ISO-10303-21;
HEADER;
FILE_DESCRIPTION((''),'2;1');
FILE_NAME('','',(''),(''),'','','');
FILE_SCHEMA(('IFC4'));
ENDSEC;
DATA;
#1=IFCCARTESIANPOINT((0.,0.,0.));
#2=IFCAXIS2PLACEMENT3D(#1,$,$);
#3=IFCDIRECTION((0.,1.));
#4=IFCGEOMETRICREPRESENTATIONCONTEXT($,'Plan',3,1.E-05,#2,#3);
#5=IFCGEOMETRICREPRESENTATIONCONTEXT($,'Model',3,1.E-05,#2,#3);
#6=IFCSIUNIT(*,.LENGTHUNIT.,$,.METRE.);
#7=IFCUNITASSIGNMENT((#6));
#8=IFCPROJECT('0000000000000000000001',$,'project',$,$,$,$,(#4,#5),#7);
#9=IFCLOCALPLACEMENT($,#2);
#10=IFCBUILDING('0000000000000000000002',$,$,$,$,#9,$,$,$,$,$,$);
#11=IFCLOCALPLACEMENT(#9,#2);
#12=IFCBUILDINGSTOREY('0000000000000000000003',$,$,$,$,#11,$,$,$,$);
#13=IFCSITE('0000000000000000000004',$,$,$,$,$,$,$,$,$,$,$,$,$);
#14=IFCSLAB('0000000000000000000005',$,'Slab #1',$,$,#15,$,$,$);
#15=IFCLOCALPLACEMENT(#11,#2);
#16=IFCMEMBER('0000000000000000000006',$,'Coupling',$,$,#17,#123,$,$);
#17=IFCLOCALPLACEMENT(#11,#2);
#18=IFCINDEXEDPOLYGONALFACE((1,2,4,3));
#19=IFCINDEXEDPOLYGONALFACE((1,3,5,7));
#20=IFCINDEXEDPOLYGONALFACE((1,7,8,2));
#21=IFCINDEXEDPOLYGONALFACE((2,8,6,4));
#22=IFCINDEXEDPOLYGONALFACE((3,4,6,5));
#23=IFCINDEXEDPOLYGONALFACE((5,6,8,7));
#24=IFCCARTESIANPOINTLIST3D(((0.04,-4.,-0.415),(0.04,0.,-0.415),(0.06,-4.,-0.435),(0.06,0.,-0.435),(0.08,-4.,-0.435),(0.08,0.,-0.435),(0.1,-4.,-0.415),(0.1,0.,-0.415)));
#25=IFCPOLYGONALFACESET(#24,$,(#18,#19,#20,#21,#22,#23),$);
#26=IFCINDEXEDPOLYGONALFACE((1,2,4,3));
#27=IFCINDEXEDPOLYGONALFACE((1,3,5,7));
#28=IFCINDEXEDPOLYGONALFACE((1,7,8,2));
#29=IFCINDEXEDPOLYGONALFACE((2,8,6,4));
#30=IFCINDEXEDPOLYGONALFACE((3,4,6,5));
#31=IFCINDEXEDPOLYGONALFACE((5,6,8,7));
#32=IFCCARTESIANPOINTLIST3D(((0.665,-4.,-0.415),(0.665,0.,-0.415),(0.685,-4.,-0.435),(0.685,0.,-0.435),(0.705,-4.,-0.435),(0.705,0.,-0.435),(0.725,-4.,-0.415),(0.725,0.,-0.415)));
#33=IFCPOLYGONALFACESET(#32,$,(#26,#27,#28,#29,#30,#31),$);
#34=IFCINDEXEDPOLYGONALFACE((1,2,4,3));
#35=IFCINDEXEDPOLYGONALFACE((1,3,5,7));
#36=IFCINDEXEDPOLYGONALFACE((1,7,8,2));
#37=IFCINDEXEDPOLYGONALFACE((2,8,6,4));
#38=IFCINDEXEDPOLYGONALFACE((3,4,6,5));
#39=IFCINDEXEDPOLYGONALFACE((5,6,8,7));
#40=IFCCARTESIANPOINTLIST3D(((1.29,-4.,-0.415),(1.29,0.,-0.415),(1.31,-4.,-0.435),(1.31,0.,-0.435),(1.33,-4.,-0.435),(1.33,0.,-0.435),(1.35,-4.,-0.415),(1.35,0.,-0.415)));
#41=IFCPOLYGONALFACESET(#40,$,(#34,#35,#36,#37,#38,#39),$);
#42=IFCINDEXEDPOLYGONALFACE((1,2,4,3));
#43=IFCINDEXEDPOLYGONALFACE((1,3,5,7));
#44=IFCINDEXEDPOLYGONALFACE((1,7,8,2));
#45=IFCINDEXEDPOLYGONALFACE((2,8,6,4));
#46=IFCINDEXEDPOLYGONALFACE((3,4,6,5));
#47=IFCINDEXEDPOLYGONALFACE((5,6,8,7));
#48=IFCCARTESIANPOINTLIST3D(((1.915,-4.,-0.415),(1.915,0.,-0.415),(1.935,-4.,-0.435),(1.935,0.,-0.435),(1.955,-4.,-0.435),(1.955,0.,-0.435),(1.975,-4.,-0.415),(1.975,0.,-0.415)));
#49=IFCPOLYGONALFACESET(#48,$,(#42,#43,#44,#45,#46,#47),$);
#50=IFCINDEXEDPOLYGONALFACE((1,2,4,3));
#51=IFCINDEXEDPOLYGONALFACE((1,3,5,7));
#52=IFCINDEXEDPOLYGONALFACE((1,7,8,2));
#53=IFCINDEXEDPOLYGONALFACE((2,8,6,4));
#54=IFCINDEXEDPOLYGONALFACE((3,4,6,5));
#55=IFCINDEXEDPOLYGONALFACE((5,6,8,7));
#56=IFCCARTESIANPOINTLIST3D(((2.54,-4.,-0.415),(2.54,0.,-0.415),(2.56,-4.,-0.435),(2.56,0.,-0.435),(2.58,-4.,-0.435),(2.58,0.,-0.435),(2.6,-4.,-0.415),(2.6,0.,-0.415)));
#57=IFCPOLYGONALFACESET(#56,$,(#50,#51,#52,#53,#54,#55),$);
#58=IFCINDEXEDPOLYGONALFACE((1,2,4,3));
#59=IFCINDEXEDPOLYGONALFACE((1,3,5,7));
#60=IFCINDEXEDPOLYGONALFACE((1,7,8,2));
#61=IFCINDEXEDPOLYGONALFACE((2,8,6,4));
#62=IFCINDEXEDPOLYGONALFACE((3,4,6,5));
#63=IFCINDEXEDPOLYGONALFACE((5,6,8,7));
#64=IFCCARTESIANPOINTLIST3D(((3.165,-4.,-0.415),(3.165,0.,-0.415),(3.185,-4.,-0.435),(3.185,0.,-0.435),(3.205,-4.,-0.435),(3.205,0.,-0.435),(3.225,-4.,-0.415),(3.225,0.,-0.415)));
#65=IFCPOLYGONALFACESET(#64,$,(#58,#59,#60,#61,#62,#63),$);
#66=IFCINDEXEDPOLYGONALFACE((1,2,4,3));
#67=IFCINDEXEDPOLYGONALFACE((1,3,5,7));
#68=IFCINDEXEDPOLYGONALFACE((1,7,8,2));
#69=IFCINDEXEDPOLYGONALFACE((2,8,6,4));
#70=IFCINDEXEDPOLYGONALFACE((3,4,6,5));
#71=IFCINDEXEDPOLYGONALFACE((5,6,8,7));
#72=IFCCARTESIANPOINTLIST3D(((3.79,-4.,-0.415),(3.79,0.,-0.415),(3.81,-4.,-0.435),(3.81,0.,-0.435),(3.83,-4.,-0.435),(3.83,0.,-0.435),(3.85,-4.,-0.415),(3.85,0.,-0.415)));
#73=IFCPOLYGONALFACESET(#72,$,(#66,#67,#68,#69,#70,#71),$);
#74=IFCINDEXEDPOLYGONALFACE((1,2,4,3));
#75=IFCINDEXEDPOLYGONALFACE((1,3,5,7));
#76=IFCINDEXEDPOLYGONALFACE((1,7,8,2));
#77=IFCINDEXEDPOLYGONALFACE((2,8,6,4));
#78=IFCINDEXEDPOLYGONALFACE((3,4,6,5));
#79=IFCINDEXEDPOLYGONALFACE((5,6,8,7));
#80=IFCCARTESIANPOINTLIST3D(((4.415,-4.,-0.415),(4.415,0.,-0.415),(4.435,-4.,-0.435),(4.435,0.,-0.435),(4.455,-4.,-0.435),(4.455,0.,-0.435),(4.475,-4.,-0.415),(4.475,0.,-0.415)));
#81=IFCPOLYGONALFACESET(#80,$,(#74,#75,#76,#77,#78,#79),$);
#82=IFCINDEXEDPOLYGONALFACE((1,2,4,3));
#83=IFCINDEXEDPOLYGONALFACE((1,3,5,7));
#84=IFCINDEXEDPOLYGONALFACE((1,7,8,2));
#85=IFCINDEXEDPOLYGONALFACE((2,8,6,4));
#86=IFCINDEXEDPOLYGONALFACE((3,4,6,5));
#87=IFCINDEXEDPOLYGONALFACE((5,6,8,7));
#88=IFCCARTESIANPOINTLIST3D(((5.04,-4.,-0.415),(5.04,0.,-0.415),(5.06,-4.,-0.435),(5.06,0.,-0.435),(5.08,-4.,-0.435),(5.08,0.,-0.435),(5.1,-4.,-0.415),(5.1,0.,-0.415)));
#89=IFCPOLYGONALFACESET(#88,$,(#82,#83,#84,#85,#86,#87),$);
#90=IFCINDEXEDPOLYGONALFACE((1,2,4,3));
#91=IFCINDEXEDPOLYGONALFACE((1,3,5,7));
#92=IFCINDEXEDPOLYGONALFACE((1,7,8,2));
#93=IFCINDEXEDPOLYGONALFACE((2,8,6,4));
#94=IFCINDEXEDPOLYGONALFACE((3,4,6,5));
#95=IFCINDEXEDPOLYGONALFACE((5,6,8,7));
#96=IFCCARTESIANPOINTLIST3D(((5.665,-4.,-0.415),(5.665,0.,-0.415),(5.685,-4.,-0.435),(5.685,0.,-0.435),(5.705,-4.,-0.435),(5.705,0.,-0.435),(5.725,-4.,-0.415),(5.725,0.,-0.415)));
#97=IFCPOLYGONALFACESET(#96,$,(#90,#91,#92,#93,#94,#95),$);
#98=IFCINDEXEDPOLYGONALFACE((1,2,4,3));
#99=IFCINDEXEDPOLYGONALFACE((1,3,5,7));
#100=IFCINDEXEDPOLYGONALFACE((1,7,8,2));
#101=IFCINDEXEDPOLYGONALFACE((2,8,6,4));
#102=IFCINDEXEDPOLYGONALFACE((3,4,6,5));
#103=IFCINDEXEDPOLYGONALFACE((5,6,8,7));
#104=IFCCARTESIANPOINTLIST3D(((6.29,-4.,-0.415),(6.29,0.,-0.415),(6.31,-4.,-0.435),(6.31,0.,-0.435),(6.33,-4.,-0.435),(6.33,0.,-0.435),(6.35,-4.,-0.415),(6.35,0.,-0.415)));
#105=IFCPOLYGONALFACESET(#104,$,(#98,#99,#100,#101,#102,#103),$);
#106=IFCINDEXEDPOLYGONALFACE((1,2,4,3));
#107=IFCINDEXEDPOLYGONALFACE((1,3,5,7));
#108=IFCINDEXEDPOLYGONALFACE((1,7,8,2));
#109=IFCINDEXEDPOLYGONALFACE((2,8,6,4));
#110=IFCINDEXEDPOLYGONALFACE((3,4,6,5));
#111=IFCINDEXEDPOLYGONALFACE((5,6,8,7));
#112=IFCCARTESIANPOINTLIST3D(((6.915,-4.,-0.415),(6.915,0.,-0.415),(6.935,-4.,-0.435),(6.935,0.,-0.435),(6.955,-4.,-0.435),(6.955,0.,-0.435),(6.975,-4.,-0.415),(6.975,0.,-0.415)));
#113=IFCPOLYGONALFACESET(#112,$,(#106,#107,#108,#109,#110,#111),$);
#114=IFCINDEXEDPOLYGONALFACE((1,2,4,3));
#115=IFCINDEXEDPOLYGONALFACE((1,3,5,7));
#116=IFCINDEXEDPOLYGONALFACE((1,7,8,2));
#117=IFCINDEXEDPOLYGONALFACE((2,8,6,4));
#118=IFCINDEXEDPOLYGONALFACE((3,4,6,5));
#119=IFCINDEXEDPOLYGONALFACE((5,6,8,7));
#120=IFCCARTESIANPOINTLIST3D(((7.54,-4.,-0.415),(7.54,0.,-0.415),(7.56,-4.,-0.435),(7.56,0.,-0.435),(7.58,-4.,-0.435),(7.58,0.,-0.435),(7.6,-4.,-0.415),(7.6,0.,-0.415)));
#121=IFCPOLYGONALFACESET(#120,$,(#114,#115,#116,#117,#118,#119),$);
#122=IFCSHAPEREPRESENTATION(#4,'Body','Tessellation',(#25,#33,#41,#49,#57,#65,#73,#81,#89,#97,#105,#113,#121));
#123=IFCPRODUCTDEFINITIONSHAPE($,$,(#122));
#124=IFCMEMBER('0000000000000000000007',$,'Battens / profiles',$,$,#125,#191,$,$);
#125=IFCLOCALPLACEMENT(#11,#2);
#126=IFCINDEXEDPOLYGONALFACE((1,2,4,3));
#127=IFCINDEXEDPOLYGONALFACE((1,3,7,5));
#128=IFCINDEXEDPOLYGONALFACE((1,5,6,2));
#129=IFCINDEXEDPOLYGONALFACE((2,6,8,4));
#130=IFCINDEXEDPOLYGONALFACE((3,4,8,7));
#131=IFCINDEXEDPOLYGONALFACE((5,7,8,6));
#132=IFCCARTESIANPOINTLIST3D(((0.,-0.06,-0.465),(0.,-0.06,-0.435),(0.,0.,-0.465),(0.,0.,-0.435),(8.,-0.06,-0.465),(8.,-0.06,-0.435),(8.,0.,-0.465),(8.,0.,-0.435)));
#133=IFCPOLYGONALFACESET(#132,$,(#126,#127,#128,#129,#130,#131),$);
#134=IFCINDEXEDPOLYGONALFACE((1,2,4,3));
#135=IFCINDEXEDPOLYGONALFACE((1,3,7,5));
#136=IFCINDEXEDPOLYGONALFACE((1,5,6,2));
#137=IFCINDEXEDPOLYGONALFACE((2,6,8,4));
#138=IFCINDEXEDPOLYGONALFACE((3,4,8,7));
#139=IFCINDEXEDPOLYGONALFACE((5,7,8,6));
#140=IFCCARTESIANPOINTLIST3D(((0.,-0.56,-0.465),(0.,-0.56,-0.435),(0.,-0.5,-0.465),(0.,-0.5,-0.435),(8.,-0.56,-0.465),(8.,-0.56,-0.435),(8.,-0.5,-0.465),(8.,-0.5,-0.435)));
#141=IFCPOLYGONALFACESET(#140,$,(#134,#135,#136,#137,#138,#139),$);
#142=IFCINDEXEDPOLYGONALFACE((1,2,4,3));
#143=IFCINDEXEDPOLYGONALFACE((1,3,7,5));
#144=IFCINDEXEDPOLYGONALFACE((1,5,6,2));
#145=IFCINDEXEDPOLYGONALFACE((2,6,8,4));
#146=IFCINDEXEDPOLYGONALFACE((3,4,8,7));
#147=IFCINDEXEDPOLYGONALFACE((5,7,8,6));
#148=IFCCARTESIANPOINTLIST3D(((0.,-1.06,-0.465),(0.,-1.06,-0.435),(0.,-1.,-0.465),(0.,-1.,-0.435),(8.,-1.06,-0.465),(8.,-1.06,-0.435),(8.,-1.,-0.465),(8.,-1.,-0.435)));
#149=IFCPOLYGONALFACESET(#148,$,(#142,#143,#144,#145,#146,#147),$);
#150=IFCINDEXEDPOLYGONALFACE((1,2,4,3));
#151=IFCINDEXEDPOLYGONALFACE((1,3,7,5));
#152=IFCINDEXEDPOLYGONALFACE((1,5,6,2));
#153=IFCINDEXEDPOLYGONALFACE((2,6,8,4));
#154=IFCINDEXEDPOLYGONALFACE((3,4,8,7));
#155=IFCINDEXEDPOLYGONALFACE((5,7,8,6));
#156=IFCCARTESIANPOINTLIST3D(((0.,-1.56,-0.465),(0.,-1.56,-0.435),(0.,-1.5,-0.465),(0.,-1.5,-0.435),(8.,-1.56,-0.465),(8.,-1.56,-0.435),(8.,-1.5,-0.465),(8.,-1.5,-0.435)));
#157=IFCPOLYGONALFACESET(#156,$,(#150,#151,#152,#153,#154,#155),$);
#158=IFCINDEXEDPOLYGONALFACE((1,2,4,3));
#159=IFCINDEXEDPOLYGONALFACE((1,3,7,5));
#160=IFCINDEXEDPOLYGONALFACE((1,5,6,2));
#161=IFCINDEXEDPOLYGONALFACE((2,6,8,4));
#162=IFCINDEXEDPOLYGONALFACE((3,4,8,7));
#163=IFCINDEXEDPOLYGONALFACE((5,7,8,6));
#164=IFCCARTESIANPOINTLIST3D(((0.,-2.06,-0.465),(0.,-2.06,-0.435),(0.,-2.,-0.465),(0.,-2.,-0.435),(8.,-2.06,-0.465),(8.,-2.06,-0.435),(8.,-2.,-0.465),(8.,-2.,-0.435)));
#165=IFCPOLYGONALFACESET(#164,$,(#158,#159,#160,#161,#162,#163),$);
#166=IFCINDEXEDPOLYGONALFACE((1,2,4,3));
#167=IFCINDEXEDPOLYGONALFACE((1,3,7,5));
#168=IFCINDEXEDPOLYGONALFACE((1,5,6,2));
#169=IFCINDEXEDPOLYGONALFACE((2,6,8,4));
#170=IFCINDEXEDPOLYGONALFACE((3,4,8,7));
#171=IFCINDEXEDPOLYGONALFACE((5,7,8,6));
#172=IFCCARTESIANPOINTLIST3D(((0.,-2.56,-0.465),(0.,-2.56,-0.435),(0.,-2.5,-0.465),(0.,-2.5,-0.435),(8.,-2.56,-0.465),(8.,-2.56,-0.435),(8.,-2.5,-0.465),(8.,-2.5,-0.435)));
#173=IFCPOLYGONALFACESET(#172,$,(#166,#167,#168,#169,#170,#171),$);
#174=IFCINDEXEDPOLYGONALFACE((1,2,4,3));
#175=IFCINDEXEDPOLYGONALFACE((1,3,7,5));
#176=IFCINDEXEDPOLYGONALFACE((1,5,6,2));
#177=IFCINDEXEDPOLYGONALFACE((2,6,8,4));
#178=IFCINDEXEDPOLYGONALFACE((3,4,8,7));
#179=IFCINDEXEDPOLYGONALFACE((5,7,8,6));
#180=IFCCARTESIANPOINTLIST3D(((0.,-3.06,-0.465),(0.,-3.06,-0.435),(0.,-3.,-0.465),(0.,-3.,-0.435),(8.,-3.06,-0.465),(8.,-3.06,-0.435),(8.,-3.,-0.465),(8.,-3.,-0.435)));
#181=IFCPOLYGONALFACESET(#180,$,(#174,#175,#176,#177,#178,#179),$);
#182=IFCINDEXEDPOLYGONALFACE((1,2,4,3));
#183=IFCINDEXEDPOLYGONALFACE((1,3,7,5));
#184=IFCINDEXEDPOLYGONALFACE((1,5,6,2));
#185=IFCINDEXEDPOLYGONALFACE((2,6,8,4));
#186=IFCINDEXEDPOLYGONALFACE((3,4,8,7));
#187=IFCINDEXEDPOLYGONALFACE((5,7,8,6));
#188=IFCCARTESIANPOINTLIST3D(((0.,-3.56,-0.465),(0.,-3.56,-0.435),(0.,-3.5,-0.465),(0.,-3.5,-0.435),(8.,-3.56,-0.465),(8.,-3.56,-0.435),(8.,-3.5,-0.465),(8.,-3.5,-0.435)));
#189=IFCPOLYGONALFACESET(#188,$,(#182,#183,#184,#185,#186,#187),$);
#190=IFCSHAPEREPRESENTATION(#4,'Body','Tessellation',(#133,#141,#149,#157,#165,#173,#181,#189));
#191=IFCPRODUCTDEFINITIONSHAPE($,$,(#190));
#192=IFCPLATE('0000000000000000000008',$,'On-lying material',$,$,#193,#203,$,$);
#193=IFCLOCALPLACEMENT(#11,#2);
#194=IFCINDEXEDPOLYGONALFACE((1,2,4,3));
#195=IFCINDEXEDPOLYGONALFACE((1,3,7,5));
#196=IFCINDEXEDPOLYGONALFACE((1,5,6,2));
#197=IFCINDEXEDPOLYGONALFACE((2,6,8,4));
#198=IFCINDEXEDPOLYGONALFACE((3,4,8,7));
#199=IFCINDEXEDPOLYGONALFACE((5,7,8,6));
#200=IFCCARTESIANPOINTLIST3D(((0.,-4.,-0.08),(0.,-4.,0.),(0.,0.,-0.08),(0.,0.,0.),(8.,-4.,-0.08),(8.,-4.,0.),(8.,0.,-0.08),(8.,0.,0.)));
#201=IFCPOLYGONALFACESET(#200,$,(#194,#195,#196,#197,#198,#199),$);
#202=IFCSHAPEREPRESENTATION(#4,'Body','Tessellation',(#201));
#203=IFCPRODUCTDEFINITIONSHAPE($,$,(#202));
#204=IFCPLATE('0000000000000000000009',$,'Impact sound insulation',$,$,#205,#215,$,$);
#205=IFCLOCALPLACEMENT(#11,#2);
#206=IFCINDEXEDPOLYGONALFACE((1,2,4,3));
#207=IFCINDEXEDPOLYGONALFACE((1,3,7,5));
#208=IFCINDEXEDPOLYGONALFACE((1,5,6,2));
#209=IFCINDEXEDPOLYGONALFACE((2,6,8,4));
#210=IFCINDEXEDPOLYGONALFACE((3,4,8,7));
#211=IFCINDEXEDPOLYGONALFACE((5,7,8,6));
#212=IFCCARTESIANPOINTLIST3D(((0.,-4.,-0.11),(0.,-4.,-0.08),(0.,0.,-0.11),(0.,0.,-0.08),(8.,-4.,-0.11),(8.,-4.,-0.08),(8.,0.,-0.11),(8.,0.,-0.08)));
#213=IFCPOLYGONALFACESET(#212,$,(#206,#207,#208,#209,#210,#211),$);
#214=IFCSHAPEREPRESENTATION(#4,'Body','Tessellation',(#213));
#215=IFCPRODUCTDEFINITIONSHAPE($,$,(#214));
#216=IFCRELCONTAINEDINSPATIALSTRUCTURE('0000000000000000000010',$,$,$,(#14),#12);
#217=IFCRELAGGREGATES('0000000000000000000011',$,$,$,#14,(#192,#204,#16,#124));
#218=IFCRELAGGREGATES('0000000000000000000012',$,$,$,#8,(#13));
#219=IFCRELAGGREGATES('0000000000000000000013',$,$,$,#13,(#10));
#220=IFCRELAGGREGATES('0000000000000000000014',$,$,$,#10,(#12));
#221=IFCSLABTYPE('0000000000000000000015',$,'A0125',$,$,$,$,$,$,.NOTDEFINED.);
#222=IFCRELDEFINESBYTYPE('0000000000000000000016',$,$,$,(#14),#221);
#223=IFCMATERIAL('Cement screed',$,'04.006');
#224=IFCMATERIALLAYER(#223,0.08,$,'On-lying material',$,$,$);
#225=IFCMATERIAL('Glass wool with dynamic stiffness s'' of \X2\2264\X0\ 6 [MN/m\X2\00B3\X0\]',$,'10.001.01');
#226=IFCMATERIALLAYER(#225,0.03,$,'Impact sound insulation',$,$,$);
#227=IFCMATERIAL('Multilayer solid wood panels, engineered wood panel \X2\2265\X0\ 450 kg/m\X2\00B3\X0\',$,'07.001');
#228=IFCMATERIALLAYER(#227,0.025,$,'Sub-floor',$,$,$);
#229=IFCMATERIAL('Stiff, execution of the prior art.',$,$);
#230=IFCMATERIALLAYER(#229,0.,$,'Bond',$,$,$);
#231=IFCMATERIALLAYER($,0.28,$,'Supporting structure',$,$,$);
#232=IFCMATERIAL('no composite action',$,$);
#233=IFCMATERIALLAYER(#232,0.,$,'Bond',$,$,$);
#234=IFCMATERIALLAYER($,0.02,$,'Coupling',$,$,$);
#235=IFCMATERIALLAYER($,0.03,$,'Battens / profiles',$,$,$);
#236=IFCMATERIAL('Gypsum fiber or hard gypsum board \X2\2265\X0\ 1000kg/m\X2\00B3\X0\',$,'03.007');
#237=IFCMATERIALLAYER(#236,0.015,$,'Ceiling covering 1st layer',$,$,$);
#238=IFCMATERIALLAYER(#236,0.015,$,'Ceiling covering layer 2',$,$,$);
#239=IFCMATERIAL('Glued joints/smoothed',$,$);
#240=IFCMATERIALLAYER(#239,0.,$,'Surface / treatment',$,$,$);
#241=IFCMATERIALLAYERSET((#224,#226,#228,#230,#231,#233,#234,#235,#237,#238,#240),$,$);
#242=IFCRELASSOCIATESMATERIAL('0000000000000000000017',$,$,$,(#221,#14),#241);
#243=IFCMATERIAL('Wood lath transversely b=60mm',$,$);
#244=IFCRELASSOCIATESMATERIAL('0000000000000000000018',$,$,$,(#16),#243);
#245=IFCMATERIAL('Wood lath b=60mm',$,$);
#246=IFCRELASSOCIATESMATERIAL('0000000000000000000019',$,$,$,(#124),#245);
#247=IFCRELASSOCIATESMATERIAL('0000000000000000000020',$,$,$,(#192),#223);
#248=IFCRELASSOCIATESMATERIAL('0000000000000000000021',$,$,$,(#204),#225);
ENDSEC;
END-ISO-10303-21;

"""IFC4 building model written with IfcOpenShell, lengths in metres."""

from ifc_helpers import new_model, si_unit, direction, frame, frame_2d, origin, origin_with_axes, place, context, project, spatial, polyline, rectangle, outline, extrude, material, layer, layer_set, type_object, element, aggregate, save


model = new_model("IFC4")

# Units and contexts
plan_context = context("Plan", 3, precision=1e-05, world=origin(), true_north=direction((0.0, 1.0)))
model_context = context("Model", 3, precision=1e-05, world=origin(), true_north=direction((0.0, 1.0)))
ifc_project = project(units=[si_unit("LENGTHUNIT", "METRE")], contexts=[plan_context, model_context])

# Site, building, storey
site = spatial("IfcSite", under=ifc_project)
building_placement = place(None, origin())
building = spatial("IfcBuilding", under=site, at=building_placement)
storey_placement = place(building_placement, origin())
storey = spatial("IfcBuildingStorey", under=building, at=storey_placement)

# Slab, members, plates
ifc_material_1 = material(Name="Cement screed", Category="04.006")
ifc_layer_1 = layer(ifc_material_1, 0.08, Name="On-lying material")
ifc_material_2 = material(Name="Glass wool with dynamic stiffness s' of ≤ 6 [MN/m³]", Category="10.001.01")
ifc_layer_2 = layer(ifc_material_2, 0.03, Name="Impact sound insulation")
ifc_material_3 = material(Name="Multilayer solid wood panels, engineered wood panel ≥ 450 kg/m³", Category="07.001")
ifc_layer_3 = layer(ifc_material_3, 0.025, Name="Sub-floor")
ifc_material_4 = material(Name="Stiff, execution of the prior art.")
ifc_layer_4 = layer(ifc_material_4, 0.0, Name="Bond")
ifc_layer_5 = layer(None, 0.28, Name="Supporting structure")
ifc_material_5 = material(Name="no composite action")
ifc_layer_6 = layer(ifc_material_5, 0.0, Name="Bond")
ifc_layer_7 = layer(None, 0.02, Name="Coupling")
ifc_layer_8 = layer(None, 0.03, Name="Battens / profiles")
ifc_material_6 = material(Name="Gypsum fiber or hard gypsum board ≥ 1000kg/m³", Category="03.007")
ifc_layer_9 = layer(ifc_material_6, 0.015, Name="Ceiling covering 1st layer")
ifc_layer_10 = layer(ifc_material_6, 0.015, Name="Ceiling covering layer 2")
ifc_material_7 = material(Name="Glued joints/smoothed")
ifc_layer_11 = layer(ifc_material_7, 0.0, Name="Surface / treatment")
ifc_layer_set = layer_set([ifc_layer_1, ifc_layer_2, ifc_layer_3, ifc_layer_4, ifc_layer_5, ifc_layer_6, ifc_layer_7, ifc_layer_8, ifc_layer_9, ifc_layer_10, ifc_layer_11])
slab_type = type_object("IfcSlabType", Name="A0125", PredefinedType="NOTDEFINED", material=ifc_layer_set)
slab_placement = place(None, frame((0.0, 0.0, 0.0), z_axis=(0.0, 0.0, -1.0), x_axis=(1.0, 0.0, 0.0)))
slab = element("IfcSlab", 1, at=slab_placement, inside=storey, type_object=slab_type, material=ifc_layer_set, Name="Slab #1")
ifc_material_8 = material(Name="Wood lath transversely b=60mm")
member_1_placement = place(slab_placement, origin())
member_1 = element("IfcMember", 2, at=member_1_placement, material=ifc_material_8, Name="Coupling", context=plan_context, shape_type="SweptSolid", body=[
    extrude(outline(polyline([(0.0, 0.0), (0.06, 0.0), (0.04, 0.02), (0.02, 0.02), (0.0, 0.0)])), frame((0.04, 4.0, 0.415), z_axis=(0.0, -1.0, 0.0), x_axis=(1.0, 0.0, 0.0)), (0.0, 0.0, 1.0), 4.0),
    extrude(outline(polyline([(0.0, 0.0), (0.06, 0.0), (0.04, 0.02), (0.02, 0.02), (0.0, 0.0)])), frame((0.665, 4.0, 0.415), z_axis=(0.0, -1.0, 0.0), x_axis=(1.0, 0.0, 0.0)), (0.0, 0.0, 1.0), 4.0),
    extrude(outline(polyline([(0.0, 0.0), (0.06, 0.0), (0.04, 0.02), (0.02, 0.02), (0.0, 0.0)])), frame((1.29, 4.0, 0.415), z_axis=(0.0, -1.0, 0.0), x_axis=(1.0, 0.0, 0.0)), (0.0, 0.0, 1.0), 4.0),
    extrude(outline(polyline([(0.0, 0.0), (0.06, 0.0), (0.04, 0.02), (0.02, 0.02), (0.0, 0.0)])), frame((1.915, 4.0, 0.415), z_axis=(0.0, -1.0, 0.0), x_axis=(1.0, 0.0, 0.0)), (0.0, 0.0, 1.0), 4.0),
    extrude(outline(polyline([(0.0, 0.0), (0.06, 0.0), (0.04, 0.02), (0.02, 0.02), (0.0, 0.0)])), frame((2.54, 4.0, 0.415), z_axis=(0.0, -1.0, 0.0), x_axis=(1.0, 0.0, 0.0)), (0.0, 0.0, 1.0), 4.0),
    extrude(outline(polyline([(0.0, 0.0), (0.06, 0.0), (0.04, 0.02), (0.02, 0.02), (0.0, 0.0)])), frame((3.165, 4.0, 0.415), z_axis=(0.0, -1.0, 0.0), x_axis=(1.0, 0.0, 0.0)), (0.0, 0.0, 1.0), 4.0),
    extrude(outline(polyline([(0.0, 0.0), (0.06, 0.0), (0.04, 0.02), (0.02, 0.02), (0.0, 0.0)])), frame((3.79, 4.0, 0.415), z_axis=(0.0, -1.0, 0.0), x_axis=(1.0, 0.0, 0.0)), (0.0, 0.0, 1.0), 4.0),
    extrude(outline(polyline([(0.0, 0.0), (0.06, 0.0), (0.04, 0.02), (0.02, 0.02), (0.0, 0.0)])), frame((4.415, 4.0, 0.415), z_axis=(0.0, -1.0, 0.0), x_axis=(1.0, 0.0, 0.0)), (0.0, 0.0, 1.0), 4.0),
    extrude(outline(polyline([(0.0, 0.0), (0.06, 0.0), (0.04, 0.02), (0.02, 0.02), (0.0, 0.0)])), frame((5.04, 4.0, 0.415), z_axis=(0.0, -1.0, 0.0), x_axis=(1.0, 0.0, 0.0)), (0.0, 0.0, 1.0), 4.0),
    extrude(outline(polyline([(0.0, 0.0), (0.06, 0.0), (0.04, 0.02), (0.02, 0.02), (0.0, 0.0)])), frame((5.665, 4.0, 0.415), z_axis=(0.0, -1.0, 0.0), x_axis=(1.0, 0.0, 0.0)), (0.0, 0.0, 1.0), 4.0),
    extrude(outline(polyline([(0.0, 0.0), (0.06, 0.0), (0.04, 0.02), (0.02, 0.02), (0.0, 0.0)])), frame((6.29, 4.0, 0.415), z_axis=(0.0, -1.0, 0.0), x_axis=(1.0, 0.0, 0.0)), (0.0, 0.0, 1.0), 4.0),
    extrude(outline(polyline([(0.0, 0.0), (0.06, 0.0), (0.04, 0.02), (0.02, 0.02), (0.0, 0.0)])), frame((6.915, 4.0, 0.415), z_axis=(0.0, -1.0, 0.0), x_axis=(1.0, 0.0, 0.0)), (0.0, 0.0, 1.0), 4.0),
    extrude(outline(polyline([(0.0, 0.0), (0.06, 0.0), (0.04, 0.02), (0.02, 0.02), (0.0, 0.0)])), frame((7.54, 4.0, 0.415), z_axis=(0.0, -1.0, 0.0), x_axis=(1.0, 0.0, 0.0)), (0.0, 0.0, 1.0), 4.0),
])
ifc_material_9 = material(Name="Wood lath b=60mm")
member_2_placement = place(slab_placement, origin())
member_2 = element("IfcMember", 3, at=member_2_placement, material=ifc_material_9, Name="Battens / profiles", context=plan_context, shape_type="SweptSolid", body=[
    extrude(rectangle(XDim=0.06, YDim=0.03, at=frame_2d((0.03, 0.015), x_axis=(1.0, 0.0))), frame((0.0, 0.0, 0.435), z_axis=(1.0, 0.0, 0.0), x_axis=(0.0, 1.0, 0.0)), (0.0, 0.0, 1.0), 8.0),
    extrude(rectangle(XDim=0.06, YDim=0.03, at=frame_2d((0.03, 0.015), x_axis=(1.0, 0.0))), frame((0.0, 0.5, 0.435), z_axis=(1.0, 0.0, 0.0), x_axis=(0.0, 1.0, 0.0)), (0.0, 0.0, 1.0), 8.0),
    extrude(rectangle(XDim=0.06, YDim=0.03, at=frame_2d((0.03, 0.015), x_axis=(1.0, 0.0))), frame((0.0, 1.0, 0.435), z_axis=(1.0, 0.0, 0.0), x_axis=(0.0, 1.0, 0.0)), (0.0, 0.0, 1.0), 8.0),
    extrude(rectangle(XDim=0.06, YDim=0.03, at=frame_2d((0.03, 0.015), x_axis=(1.0, 0.0))), frame((0.0, 1.5, 0.435), z_axis=(1.0, 0.0, 0.0), x_axis=(0.0, 1.0, 0.0)), (0.0, 0.0, 1.0), 8.0),
    extrude(rectangle(XDim=0.06, YDim=0.03, at=frame_2d((0.03, 0.015), x_axis=(1.0, 0.0))), frame((0.0, 2.0, 0.435), z_axis=(1.0, 0.0, 0.0), x_axis=(0.0, 1.0, 0.0)), (0.0, 0.0, 1.0), 8.0),
    extrude(rectangle(XDim=0.06, YDim=0.03, at=frame_2d((0.03, 0.015), x_axis=(1.0, 0.0))), frame((0.0, 2.5, 0.435), z_axis=(1.0, 0.0, 0.0), x_axis=(0.0, 1.0, 0.0)), (0.0, 0.0, 1.0), 8.0),
    extrude(rectangle(XDim=0.06, YDim=0.03, at=frame_2d((0.03, 0.015), x_axis=(1.0, 0.0))), frame((0.0, 3.0, 0.435), z_axis=(1.0, 0.0, 0.0), x_axis=(0.0, 1.0, 0.0)), (0.0, 0.0, 1.0), 8.0),
    extrude(rectangle(XDim=0.06, YDim=0.03, at=frame_2d((0.03, 0.015), x_axis=(1.0, 0.0))), frame((0.0, 3.5, 0.435), z_axis=(1.0, 0.0, 0.0), x_axis=(0.0, 1.0, 0.0)), (0.0, 0.0, 1.0), 8.0),
])
plate_1_placement = place(slab_placement, origin())
plate_1 = element("IfcPlate", 4, at=plate_1_placement, material=ifc_material_1, Name="On-lying material", context=plan_context, shape_type="SweptSolid", body=[
    extrude(rectangle(XDim=8.0, YDim=4.0, at=frame_2d((4.0, 2.0), x_axis=(1.0, 0.0))), origin_with_axes(), (0.0, 0.0, 1.0), 0.08),
])
plate_2_placement = place(slab_placement, origin())
plate_2 = element("IfcPlate", 5, at=plate_2_placement, material=ifc_material_2, Name="Impact sound insulation", context=plan_context, shape_type="SweptSolid", body=[
    extrude(rectangle(XDim=8.0, YDim=4.0, at=frame_2d((4.0, 2.0), x_axis=(1.0, 0.0))), frame((0.0, 0.0, 0.08), z_axis=(0.0, 0.0, 1.0), x_axis=(1.0, 0.0, 0.0)), (0.0, 0.0, 1.0), 0.03),
])
aggregate(slab, [plate_1, plate_2, member_1, member_2])

save(model, "model.ifc")
